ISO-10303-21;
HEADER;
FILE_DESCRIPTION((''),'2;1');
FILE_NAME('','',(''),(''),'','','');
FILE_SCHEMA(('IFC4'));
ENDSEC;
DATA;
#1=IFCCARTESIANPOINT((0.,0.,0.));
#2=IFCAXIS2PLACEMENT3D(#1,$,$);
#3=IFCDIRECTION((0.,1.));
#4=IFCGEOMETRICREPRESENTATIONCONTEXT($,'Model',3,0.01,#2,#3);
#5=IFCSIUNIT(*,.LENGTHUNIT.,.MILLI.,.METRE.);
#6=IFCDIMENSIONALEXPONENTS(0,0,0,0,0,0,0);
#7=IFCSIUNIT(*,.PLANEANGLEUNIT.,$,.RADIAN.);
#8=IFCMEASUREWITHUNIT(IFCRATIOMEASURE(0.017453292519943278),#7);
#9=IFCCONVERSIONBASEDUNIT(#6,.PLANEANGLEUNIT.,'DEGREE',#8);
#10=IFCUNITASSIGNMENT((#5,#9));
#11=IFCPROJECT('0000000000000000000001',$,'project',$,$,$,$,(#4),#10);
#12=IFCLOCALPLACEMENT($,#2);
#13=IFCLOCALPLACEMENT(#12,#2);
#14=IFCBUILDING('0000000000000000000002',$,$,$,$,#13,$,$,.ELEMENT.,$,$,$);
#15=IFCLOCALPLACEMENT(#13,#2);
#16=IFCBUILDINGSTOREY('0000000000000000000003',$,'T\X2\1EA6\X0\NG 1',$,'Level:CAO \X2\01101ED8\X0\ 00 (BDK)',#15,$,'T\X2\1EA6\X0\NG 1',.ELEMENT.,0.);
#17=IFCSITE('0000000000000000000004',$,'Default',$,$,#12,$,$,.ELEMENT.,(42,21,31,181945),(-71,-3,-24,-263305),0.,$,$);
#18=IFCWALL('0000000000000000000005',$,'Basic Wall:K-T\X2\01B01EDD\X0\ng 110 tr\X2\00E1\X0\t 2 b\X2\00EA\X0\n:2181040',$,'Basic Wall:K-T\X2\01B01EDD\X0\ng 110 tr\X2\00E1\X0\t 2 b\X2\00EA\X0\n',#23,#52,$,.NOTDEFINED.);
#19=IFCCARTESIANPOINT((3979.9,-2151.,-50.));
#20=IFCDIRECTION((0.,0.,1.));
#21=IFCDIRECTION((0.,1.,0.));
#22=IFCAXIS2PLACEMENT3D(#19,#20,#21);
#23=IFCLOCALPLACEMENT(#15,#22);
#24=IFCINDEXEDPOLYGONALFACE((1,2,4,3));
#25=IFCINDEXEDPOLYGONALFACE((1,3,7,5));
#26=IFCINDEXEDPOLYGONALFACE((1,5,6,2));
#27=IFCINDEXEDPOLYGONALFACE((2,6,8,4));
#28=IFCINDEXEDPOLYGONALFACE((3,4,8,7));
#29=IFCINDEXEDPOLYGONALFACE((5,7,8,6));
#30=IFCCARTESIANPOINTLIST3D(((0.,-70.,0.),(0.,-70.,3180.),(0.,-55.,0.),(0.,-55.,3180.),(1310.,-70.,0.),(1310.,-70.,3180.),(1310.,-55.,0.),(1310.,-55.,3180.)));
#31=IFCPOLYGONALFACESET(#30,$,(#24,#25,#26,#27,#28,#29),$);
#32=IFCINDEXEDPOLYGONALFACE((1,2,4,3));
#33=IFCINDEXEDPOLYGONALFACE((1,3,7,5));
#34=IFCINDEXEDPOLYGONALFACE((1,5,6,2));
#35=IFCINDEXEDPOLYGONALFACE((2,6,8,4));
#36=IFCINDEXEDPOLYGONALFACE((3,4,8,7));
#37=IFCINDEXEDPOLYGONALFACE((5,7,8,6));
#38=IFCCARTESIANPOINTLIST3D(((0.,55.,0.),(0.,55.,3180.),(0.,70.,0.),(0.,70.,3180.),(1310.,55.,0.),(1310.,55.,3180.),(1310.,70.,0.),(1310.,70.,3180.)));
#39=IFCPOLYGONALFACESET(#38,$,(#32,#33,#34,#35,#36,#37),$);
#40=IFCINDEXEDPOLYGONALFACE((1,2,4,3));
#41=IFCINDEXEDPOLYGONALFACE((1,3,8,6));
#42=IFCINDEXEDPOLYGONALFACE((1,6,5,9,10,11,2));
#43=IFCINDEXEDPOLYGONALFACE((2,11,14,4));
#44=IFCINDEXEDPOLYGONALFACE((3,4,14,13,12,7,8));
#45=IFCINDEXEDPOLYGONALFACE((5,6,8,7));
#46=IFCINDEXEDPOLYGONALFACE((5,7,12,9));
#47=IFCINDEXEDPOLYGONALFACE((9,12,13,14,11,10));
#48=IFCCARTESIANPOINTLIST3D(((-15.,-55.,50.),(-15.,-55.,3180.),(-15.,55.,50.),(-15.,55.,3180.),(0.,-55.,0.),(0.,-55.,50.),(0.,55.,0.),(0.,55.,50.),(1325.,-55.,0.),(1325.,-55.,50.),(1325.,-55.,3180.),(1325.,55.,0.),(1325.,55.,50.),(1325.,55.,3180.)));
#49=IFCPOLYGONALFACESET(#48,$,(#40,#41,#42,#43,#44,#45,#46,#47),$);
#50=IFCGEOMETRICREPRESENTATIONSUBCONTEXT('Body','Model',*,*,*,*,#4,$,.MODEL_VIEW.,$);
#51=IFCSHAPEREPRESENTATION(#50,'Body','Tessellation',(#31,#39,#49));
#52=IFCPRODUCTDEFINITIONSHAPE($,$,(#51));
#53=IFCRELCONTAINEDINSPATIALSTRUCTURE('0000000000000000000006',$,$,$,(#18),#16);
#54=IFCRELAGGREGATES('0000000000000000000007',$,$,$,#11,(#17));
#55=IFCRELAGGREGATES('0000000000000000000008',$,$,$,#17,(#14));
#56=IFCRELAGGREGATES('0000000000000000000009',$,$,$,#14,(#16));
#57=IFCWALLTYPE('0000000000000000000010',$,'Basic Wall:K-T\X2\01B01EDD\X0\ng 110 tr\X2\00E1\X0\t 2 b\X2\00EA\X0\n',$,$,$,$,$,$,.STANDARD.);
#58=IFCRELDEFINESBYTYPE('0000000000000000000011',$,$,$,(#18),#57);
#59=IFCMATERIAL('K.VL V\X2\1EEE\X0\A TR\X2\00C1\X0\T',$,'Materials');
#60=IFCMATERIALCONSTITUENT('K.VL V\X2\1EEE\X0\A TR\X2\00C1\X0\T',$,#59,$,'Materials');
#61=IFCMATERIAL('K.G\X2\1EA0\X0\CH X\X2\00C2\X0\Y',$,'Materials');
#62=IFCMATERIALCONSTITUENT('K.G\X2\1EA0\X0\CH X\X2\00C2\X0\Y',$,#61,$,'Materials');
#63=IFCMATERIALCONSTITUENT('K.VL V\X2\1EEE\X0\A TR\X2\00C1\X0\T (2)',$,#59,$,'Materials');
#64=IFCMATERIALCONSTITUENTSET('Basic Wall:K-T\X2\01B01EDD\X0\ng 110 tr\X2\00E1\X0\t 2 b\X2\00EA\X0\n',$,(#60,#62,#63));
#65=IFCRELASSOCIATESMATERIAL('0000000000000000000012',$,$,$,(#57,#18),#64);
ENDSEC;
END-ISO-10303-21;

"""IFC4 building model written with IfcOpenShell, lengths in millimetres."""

from ifc_helpers import new_model, entity, si_unit, converted_unit, direction, frame, origin, place, context, subcontext, project, spatial, indexed_curve, outline, extrude, material, constituent, constituent_set, type_object, element, save


model = new_model("IFC4")

# Units and contexts
model_context = context("Model", 3, precision=0.01, world=origin(), true_north=direction((0.0, 1.0)))
body_context = subcontext(model_context, "Body", "Model", "MODEL_VIEW")
ifc_project = project(units=[si_unit("LENGTHUNIT", "METRE", prefix="MILLI"), converted_unit("PLANEANGLEUNIT", "DEGREE", entity("IfcRatioMeasure", 0.017453292519943278), si_unit("PLANEANGLEUNIT", "RADIAN"), dimensions=[0, 0, 0, 0, 0, 0, 0])], contexts=[model_context])

# Site, building, storey
site_placement = place(None, origin())
site = spatial("IfcSite", under=ifc_project, at=site_placement, Name="Default", CompositionType="ELEMENT", RefLatitude=(42, 21, 31, 181945), RefLongitude=(-71, -3, -24, -263305), RefElevation=0.0)
building_placement = place(site_placement, origin())
building = spatial("IfcBuilding", under=site, at=building_placement, CompositionType="ELEMENT")
storey_placement = place(building_placement, origin())
storey = spatial("IfcBuildingStorey", under=building, at=storey_placement, Name="TẦNG 1", ObjectType="Level:CAO ĐỘ 00 (BDK)", LongName="TẦNG 1", CompositionType="ELEMENT", Elevation=0.0)

# Wall
ifc_material_1 = material(Name="K.VL VỮA TRÁT", Category="Materials")
ifc_constituent_1 = constituent(ifc_material_1, Name="K.VL VỮA TRÁT", Category="Materials")
ifc_material_2 = material(Name="K.GẠCH XÂY", Category="Materials")
ifc_constituent_2 = constituent(ifc_material_2, Name="K.GẠCH XÂY", Category="Materials")
ifc_constituent_3 = constituent(ifc_material_1, Name="K.VL VỮA TRÁT (2)", Category="Materials")
ifc_constituent_set_1 = constituent_set(constituents=[ifc_constituent_1, ifc_constituent_2, ifc_constituent_3], Name="Basic Wall:K-Tường 110 trát 2 bên")
wall_type_1 = type_object("IfcWallType", Name="Basic Wall:K-Tường 110 trát 2 bên", PredefinedType="STANDARD", material=ifc_constituent_set_1)
wall_1_placement = place(storey_placement, frame((3979.9, -2151.0, -50.0), z_axis=(0.0, 0.0, 1.0), x_axis=(0.0, 1.0, 0.0)))
element("IfcWall", 1, at=wall_1_placement, inside=storey, type_object=wall_type_1, material=ifc_constituent_set_1, Name="Basic Wall:K-Tường 110 trát 2 bên:2181040", ObjectType="Basic Wall:K-Tường 110 trát 2 bên", PredefinedType="NOTDEFINED", context=body_context, shape_type="SweptSolid", body=[
    extrude(outline(indexed_curve([(-7.5, -655.0), (7.5, -655.0), (7.5, 655.0), (-7.5, 655.0), (-7.5, -655.0)], self_intersect=False)), frame((655.0, -62.5, 0.0), z_axis=(0.0, 0.0, 1.0), x_axis=(0.0, 1.0, 0.0)), (0.0, 0.0, 1.0), 3180.0),
    extrude(outline(indexed_curve([(-7.5, -655.0), (7.5, -655.0), (7.5, 655.0), (-7.5, 655.0), (-7.5, -655.0)], self_intersect=False)), frame((655.0, 62.5, 0.0), z_axis=(0.0, 0.0, 1.0), x_axis=(0.0, -1.0, 0.0)), (0.0, 0.0, 1.0), 3180.0),
    extrude(outline(indexed_curve([(-930.0, -761.4), (-880.0, -761.4), (2250.0, -761.4), (2250.0, 578.6), (-880.0, 578.6), (-880.0, 563.6), (-930.0, 563.6), (-930.0, -761.4)], self_intersect=False)), frame((563.6, 55.0, 930.0), z_axis=(0.0, -1.0, 0.0), x_axis=(0.0, 0.0, 1.0)), (0.0, 0.0, 1.0), 110.0),
])

save(model, "model.ifc")
